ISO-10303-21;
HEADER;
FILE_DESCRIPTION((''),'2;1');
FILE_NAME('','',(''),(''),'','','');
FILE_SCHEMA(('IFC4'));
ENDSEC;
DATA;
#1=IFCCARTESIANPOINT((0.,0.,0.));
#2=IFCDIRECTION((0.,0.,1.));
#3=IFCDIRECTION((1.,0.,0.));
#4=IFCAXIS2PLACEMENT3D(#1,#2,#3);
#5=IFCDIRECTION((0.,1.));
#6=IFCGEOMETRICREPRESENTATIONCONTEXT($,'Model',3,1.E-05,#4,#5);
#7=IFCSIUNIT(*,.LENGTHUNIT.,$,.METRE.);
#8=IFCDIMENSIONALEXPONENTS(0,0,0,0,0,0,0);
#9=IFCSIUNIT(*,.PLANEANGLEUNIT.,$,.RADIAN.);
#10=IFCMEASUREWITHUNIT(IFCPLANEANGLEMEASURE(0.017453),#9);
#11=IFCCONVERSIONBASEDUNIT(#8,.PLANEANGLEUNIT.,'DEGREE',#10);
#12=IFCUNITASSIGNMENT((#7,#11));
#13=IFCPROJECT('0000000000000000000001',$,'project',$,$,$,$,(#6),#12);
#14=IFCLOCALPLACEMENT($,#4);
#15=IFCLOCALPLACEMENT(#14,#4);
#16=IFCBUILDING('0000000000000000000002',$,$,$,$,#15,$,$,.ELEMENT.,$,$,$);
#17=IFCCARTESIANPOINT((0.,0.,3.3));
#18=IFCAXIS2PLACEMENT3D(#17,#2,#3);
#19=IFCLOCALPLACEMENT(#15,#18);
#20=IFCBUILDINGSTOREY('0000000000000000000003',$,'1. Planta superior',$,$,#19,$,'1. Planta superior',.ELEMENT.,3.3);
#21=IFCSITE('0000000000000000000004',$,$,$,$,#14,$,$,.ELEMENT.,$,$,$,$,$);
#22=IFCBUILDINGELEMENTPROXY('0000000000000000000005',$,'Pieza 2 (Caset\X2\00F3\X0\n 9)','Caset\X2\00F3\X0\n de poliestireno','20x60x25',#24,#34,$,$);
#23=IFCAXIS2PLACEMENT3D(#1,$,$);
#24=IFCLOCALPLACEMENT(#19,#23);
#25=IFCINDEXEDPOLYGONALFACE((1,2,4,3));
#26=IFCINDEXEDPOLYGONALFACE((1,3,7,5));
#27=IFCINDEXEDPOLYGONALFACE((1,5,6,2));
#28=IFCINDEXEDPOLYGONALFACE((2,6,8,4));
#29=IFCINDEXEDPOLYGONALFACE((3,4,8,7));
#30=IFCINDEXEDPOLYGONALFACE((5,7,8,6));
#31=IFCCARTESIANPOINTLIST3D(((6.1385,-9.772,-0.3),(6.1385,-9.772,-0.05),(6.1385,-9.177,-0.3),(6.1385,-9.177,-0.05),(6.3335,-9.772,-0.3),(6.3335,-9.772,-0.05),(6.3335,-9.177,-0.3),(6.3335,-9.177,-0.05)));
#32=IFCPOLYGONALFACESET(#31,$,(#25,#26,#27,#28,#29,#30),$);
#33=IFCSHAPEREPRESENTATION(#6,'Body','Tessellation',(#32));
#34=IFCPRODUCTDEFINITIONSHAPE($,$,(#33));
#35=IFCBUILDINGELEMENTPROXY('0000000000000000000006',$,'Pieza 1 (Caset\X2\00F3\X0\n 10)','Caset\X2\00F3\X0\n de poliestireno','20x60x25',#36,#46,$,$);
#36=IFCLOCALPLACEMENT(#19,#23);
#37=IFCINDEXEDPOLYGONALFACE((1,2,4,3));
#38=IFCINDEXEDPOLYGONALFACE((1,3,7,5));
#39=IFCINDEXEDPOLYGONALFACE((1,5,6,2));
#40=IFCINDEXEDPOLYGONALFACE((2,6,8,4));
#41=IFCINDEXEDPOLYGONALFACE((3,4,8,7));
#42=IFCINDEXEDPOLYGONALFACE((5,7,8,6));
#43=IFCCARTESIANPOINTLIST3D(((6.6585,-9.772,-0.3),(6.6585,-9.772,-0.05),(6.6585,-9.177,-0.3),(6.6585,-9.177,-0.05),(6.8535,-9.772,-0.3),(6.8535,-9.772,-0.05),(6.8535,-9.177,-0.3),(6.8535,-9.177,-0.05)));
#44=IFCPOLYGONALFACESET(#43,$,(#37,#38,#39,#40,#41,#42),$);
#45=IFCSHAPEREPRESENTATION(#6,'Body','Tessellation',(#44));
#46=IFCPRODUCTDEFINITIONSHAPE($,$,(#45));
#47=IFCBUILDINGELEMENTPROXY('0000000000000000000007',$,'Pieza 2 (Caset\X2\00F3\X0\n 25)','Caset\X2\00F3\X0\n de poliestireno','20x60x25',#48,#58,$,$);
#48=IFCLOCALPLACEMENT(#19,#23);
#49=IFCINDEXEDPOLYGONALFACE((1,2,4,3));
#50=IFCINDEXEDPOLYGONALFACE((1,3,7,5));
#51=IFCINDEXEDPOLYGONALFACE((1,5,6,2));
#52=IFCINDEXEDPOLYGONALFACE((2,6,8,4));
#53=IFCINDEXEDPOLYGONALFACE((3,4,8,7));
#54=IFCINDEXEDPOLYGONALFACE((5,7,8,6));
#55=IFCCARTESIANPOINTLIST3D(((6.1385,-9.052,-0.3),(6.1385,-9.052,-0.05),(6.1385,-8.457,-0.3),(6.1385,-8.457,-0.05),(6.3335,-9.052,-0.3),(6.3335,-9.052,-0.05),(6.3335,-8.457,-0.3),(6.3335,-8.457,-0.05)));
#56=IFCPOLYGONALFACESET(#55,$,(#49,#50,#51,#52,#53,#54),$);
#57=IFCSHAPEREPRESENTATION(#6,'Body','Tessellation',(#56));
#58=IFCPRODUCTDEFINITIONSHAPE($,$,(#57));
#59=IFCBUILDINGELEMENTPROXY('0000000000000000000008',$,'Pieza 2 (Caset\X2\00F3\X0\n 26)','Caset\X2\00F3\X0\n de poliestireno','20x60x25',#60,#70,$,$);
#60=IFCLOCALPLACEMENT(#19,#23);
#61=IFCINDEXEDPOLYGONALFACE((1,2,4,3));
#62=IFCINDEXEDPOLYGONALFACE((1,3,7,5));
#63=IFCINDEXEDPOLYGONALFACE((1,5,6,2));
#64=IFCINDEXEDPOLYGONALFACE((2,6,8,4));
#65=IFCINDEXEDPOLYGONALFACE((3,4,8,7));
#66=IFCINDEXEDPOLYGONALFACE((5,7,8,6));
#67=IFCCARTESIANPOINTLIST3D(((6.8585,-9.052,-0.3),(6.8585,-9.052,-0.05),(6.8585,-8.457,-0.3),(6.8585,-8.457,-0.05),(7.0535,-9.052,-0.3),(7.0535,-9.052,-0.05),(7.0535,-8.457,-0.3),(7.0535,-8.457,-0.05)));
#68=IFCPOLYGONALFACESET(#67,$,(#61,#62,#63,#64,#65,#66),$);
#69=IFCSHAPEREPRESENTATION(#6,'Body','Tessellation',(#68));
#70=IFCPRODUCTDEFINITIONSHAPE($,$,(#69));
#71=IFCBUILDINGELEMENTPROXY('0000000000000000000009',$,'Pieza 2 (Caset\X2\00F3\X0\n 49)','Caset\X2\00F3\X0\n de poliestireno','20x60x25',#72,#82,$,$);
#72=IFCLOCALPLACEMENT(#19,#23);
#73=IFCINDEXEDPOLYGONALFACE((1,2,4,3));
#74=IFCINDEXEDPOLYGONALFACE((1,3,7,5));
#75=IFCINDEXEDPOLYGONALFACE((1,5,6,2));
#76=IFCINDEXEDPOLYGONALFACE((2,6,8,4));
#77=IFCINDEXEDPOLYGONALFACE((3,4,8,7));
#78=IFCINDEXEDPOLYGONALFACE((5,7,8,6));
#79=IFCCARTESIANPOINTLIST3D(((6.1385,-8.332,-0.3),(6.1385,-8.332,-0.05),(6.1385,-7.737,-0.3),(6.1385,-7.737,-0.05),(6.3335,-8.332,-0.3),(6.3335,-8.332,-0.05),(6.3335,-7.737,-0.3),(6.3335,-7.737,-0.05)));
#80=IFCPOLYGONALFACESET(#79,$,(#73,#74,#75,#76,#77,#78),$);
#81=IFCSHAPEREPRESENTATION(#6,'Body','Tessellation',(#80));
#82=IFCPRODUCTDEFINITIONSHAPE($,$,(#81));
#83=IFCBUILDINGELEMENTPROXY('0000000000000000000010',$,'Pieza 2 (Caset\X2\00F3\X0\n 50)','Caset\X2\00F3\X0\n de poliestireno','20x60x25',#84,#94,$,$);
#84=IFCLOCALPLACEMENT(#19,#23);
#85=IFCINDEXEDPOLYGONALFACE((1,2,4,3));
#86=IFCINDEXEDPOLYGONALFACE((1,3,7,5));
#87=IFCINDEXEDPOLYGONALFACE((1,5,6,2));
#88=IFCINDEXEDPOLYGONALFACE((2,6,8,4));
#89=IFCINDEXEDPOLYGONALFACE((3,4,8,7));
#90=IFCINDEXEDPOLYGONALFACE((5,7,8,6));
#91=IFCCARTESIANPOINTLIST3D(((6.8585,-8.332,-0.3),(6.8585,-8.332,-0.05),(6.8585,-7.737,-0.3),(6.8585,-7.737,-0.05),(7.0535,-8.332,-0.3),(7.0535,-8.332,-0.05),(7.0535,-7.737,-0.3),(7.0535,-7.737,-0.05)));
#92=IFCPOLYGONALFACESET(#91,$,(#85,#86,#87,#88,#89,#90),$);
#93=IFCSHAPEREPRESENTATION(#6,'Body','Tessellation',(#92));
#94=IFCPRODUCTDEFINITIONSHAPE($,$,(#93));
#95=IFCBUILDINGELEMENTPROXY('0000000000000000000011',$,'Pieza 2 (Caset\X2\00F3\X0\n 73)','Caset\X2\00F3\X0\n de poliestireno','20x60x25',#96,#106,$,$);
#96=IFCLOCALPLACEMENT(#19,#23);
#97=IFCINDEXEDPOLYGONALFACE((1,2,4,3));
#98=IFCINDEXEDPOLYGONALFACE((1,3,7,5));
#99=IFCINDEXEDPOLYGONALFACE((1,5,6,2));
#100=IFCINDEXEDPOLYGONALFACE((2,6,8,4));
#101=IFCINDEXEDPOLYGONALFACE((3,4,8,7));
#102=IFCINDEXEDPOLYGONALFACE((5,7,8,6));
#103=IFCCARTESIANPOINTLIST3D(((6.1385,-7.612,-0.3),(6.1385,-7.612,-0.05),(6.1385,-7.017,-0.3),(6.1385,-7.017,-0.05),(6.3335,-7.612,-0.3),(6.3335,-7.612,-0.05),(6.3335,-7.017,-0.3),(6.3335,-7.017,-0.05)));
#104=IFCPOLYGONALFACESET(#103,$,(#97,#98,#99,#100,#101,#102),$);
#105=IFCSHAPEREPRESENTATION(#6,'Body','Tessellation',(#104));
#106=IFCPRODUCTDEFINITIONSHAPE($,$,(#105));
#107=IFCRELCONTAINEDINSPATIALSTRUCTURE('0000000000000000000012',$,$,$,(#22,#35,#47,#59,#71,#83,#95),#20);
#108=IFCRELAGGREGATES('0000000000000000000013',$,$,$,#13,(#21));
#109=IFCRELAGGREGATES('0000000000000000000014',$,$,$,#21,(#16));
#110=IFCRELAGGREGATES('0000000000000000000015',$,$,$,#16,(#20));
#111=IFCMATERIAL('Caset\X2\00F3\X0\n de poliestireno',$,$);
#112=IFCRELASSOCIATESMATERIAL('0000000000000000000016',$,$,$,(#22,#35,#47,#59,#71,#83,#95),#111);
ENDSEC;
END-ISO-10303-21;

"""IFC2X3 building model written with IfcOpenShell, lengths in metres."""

from ifc_helpers import new_model, entity, si_unit, converted_unit, direction, frame, origin_with_axes, origin_2d_with_axis, place, context, project, spatial, rectangle, extrude, source, transform, mapped, material, element, save


model = new_model("IFC2X3")

# Units and contexts
model_context = context("Model", 3, precision=1e-05, world=origin_with_axes(), true_north=direction((0.0, 1.0)))
ifc_project = project(units=[si_unit("LENGTHUNIT", "METRE"), converted_unit("PLANEANGLEUNIT", "DEGREE", entity("IfcPlaneAngleMeasure", 0.017453), si_unit("PLANEANGLEUNIT", "RADIAN"), dimensions=[0, 0, 0, 0, 0, 0, 0])], contexts=[model_context])

# Site, building, storey
site_placement = place(None, origin_with_axes())
site = spatial("IfcSite", under=ifc_project, at=site_placement, CompositionType="ELEMENT")
building_placement = place(site_placement, origin_with_axes())
building = spatial("IfcBuilding", under=site, at=building_placement, CompositionType="ELEMENT")
storey_placement = place(building_placement, frame((0.0, 0.0, 3.3), z_axis=(0.0, 0.0, 1.0), x_axis=(1.0, 0.0, 0.0)))
storey = spatial("IfcBuildingStorey", under=building, at=storey_placement, Name="1. Planta superior", LongName="1. Planta superior", CompositionType="ELEMENT", Elevation=3.3)

# Building element proxies
ifc_material = material(Name="Casetón de poliestireno")
shared_shape = source(origin_with_axes(), model_context, "Body", "SweptSolid", [
    extrude(rectangle(XDim=0.195, YDim=0.25, at=origin_2d_with_axis()), origin_with_axes(), (0.0, 0.0, 1.0), 0.595),
])
placement_1 = place(storey_placement, frame((6.236, -9.772, -0.175), z_axis=(0.0, 1.0, 0.0), x_axis=(-1.0, 0.0, 0.0)))
for number, where, z_axis, x_axis, name in (
    (1, (0.0, 0.0, 0.0), (0.0, 0.0, 1.0), (1.0, 0.0, 0.0), "Pieza 2 (Casetón 9)"),
):
    element("IfcBuildingElementProxy", number, at=place(placement_1, frame(where, z_axis=z_axis, x_axis=x_axis)), inside=storey, material=ifc_material, Name=name, Description="Casetón de poliestireno", ObjectType="20x60x25", context=model_context, shape_type="MappedRepresentation", body=[
        mapped(shared_shape, transform((0.0, 0.0, 0.0), x_axis=(1.0, 0.0, 0.0), y_axis=(0.0, 1.0, 0.0), z_axis=(0.0, 0.0, 1.0))),
    ])
placement_2 = place(storey_placement, frame((6.756, -9.772, -0.175), z_axis=(0.0, 1.0, 0.0), x_axis=(-1.0, 0.0, 0.0)))
proxy_1_placement = place(placement_2, origin_with_axes())
element("IfcBuildingElementProxy", 2, at=proxy_1_placement, inside=storey, material=ifc_material, Name="Pieza 1 (Casetón 10)", Description="Casetón de poliestireno", ObjectType="20x60x25", context=model_context, shape_type="MappedRepresentation", body=[
    mapped(shared_shape, transform((0.0, 0.0, 0.0), x_axis=(1.0, 0.0, 0.0), y_axis=(0.0, 1.0, 0.0), z_axis=(0.0, 0.0, 1.0))),
])
placement_3 = place(storey_placement, frame((6.236, -9.052, -0.175), z_axis=(0.0, 1.0, 0.0), x_axis=(-1.0, 0.0, 0.0)))
for number, where, z_axis, x_axis, name in (
    (3, (0.0, 0.0, 0.0), (0.0, 0.0, 1.0), (1.0, 0.0, 0.0), "Pieza 2 (Casetón 25)"),
):
    element("IfcBuildingElementProxy", number, at=place(placement_3, frame(where, z_axis=z_axis, x_axis=x_axis)), inside=storey, material=ifc_material, Name=name, Description="Casetón de poliestireno", ObjectType="20x60x25", context=model_context, shape_type="MappedRepresentation", body=[
        mapped(shared_shape, transform((0.0, 0.0, 0.0), x_axis=(1.0, 0.0, 0.0), y_axis=(0.0, 1.0, 0.0), z_axis=(0.0, 0.0, 1.0))),
    ])
placement_4 = place(storey_placement, frame((6.956, -9.052, -0.175), z_axis=(0.0, 1.0, 0.0), x_axis=(-1.0, 0.0, 0.0)))
for number, where, z_axis, x_axis, name in (
    (4, (0.0, 0.0, 0.0), (0.0, 0.0, 1.0), (1.0, 0.0, 0.0), "Pieza 2 (Casetón 26)"),
):
    element("IfcBuildingElementProxy", number, at=place(placement_4, frame(where, z_axis=z_axis, x_axis=x_axis)), inside=storey, material=ifc_material, Name=name, Description="Casetón de poliestireno", ObjectType="20x60x25", context=model_context, shape_type="MappedRepresentation", body=[
        mapped(shared_shape, transform((0.0, 0.0, 0.0), x_axis=(1.0, 0.0, 0.0), y_axis=(0.0, 1.0, 0.0), z_axis=(0.0, 0.0, 1.0))),
    ])
placement_5 = place(storey_placement, frame((6.236, -8.332, -0.175), z_axis=(0.0, 1.0, 0.0), x_axis=(-1.0, 0.0, 0.0)))
for number, where, z_axis, x_axis, name in (
    (5, (0.0, 0.0, 0.0), (0.0, 0.0, 1.0), (1.0, 0.0, 0.0), "Pieza 2 (Casetón 49)"),
):
    element("IfcBuildingElementProxy", number, at=place(placement_5, frame(where, z_axis=z_axis, x_axis=x_axis)), inside=storey, material=ifc_material, Name=name, Description="Casetón de poliestireno", ObjectType="20x60x25", context=model_context, shape_type="MappedRepresentation", body=[
        mapped(shared_shape, transform((0.0, 0.0, 0.0), x_axis=(1.0, 0.0, 0.0), y_axis=(0.0, 1.0, 0.0), z_axis=(0.0, 0.0, 1.0))),
    ])
placement_6 = place(storey_placement, frame((6.956, -8.332, -0.175), z_axis=(0.0, 1.0, 0.0), x_axis=(-1.0, 0.0, 0.0)))
for number, where, z_axis, x_axis, name in (
    (6, (0.0, 0.0, 0.0), (0.0, 0.0, 1.0), (1.0, 0.0, 0.0), "Pieza 2 (Casetón 50)"),
):
    element("IfcBuildingElementProxy", number, at=place(placement_6, frame(where, z_axis=z_axis, x_axis=x_axis)), inside=storey, material=ifc_material, Name=name, Description="Casetón de poliestireno", ObjectType="20x60x25", context=model_context, shape_type="MappedRepresentation", body=[
        mapped(shared_shape, transform((0.0, 0.0, 0.0), x_axis=(1.0, 0.0, 0.0), y_axis=(0.0, 1.0, 0.0), z_axis=(0.0, 0.0, 1.0))),
    ])
placement_7 = place(storey_placement, frame((6.236, -7.612, -0.175), z_axis=(0.0, 1.0, 0.0), x_axis=(-1.0, 0.0, 0.0)))
for number, where, z_axis, x_axis, name in (
    (7, (0.0, 0.0, 0.0), (0.0, 0.0, 1.0), (1.0, 0.0, 0.0), "Pieza 2 (Casetón 73)"),
):
    element("IfcBuildingElementProxy", number, at=place(placement_7, frame(where, z_axis=z_axis, x_axis=x_axis)), inside=storey, material=ifc_material, Name=name, Description="Casetón de poliestireno", ObjectType="20x60x25", context=model_context, shape_type="MappedRepresentation", body=[
        mapped(shared_shape, transform((0.0, 0.0, 0.0), x_axis=(1.0, 0.0, 0.0), y_axis=(0.0, 1.0, 0.0), z_axis=(0.0, 0.0, 1.0))),
    ])

save(model, "model.ifc")
